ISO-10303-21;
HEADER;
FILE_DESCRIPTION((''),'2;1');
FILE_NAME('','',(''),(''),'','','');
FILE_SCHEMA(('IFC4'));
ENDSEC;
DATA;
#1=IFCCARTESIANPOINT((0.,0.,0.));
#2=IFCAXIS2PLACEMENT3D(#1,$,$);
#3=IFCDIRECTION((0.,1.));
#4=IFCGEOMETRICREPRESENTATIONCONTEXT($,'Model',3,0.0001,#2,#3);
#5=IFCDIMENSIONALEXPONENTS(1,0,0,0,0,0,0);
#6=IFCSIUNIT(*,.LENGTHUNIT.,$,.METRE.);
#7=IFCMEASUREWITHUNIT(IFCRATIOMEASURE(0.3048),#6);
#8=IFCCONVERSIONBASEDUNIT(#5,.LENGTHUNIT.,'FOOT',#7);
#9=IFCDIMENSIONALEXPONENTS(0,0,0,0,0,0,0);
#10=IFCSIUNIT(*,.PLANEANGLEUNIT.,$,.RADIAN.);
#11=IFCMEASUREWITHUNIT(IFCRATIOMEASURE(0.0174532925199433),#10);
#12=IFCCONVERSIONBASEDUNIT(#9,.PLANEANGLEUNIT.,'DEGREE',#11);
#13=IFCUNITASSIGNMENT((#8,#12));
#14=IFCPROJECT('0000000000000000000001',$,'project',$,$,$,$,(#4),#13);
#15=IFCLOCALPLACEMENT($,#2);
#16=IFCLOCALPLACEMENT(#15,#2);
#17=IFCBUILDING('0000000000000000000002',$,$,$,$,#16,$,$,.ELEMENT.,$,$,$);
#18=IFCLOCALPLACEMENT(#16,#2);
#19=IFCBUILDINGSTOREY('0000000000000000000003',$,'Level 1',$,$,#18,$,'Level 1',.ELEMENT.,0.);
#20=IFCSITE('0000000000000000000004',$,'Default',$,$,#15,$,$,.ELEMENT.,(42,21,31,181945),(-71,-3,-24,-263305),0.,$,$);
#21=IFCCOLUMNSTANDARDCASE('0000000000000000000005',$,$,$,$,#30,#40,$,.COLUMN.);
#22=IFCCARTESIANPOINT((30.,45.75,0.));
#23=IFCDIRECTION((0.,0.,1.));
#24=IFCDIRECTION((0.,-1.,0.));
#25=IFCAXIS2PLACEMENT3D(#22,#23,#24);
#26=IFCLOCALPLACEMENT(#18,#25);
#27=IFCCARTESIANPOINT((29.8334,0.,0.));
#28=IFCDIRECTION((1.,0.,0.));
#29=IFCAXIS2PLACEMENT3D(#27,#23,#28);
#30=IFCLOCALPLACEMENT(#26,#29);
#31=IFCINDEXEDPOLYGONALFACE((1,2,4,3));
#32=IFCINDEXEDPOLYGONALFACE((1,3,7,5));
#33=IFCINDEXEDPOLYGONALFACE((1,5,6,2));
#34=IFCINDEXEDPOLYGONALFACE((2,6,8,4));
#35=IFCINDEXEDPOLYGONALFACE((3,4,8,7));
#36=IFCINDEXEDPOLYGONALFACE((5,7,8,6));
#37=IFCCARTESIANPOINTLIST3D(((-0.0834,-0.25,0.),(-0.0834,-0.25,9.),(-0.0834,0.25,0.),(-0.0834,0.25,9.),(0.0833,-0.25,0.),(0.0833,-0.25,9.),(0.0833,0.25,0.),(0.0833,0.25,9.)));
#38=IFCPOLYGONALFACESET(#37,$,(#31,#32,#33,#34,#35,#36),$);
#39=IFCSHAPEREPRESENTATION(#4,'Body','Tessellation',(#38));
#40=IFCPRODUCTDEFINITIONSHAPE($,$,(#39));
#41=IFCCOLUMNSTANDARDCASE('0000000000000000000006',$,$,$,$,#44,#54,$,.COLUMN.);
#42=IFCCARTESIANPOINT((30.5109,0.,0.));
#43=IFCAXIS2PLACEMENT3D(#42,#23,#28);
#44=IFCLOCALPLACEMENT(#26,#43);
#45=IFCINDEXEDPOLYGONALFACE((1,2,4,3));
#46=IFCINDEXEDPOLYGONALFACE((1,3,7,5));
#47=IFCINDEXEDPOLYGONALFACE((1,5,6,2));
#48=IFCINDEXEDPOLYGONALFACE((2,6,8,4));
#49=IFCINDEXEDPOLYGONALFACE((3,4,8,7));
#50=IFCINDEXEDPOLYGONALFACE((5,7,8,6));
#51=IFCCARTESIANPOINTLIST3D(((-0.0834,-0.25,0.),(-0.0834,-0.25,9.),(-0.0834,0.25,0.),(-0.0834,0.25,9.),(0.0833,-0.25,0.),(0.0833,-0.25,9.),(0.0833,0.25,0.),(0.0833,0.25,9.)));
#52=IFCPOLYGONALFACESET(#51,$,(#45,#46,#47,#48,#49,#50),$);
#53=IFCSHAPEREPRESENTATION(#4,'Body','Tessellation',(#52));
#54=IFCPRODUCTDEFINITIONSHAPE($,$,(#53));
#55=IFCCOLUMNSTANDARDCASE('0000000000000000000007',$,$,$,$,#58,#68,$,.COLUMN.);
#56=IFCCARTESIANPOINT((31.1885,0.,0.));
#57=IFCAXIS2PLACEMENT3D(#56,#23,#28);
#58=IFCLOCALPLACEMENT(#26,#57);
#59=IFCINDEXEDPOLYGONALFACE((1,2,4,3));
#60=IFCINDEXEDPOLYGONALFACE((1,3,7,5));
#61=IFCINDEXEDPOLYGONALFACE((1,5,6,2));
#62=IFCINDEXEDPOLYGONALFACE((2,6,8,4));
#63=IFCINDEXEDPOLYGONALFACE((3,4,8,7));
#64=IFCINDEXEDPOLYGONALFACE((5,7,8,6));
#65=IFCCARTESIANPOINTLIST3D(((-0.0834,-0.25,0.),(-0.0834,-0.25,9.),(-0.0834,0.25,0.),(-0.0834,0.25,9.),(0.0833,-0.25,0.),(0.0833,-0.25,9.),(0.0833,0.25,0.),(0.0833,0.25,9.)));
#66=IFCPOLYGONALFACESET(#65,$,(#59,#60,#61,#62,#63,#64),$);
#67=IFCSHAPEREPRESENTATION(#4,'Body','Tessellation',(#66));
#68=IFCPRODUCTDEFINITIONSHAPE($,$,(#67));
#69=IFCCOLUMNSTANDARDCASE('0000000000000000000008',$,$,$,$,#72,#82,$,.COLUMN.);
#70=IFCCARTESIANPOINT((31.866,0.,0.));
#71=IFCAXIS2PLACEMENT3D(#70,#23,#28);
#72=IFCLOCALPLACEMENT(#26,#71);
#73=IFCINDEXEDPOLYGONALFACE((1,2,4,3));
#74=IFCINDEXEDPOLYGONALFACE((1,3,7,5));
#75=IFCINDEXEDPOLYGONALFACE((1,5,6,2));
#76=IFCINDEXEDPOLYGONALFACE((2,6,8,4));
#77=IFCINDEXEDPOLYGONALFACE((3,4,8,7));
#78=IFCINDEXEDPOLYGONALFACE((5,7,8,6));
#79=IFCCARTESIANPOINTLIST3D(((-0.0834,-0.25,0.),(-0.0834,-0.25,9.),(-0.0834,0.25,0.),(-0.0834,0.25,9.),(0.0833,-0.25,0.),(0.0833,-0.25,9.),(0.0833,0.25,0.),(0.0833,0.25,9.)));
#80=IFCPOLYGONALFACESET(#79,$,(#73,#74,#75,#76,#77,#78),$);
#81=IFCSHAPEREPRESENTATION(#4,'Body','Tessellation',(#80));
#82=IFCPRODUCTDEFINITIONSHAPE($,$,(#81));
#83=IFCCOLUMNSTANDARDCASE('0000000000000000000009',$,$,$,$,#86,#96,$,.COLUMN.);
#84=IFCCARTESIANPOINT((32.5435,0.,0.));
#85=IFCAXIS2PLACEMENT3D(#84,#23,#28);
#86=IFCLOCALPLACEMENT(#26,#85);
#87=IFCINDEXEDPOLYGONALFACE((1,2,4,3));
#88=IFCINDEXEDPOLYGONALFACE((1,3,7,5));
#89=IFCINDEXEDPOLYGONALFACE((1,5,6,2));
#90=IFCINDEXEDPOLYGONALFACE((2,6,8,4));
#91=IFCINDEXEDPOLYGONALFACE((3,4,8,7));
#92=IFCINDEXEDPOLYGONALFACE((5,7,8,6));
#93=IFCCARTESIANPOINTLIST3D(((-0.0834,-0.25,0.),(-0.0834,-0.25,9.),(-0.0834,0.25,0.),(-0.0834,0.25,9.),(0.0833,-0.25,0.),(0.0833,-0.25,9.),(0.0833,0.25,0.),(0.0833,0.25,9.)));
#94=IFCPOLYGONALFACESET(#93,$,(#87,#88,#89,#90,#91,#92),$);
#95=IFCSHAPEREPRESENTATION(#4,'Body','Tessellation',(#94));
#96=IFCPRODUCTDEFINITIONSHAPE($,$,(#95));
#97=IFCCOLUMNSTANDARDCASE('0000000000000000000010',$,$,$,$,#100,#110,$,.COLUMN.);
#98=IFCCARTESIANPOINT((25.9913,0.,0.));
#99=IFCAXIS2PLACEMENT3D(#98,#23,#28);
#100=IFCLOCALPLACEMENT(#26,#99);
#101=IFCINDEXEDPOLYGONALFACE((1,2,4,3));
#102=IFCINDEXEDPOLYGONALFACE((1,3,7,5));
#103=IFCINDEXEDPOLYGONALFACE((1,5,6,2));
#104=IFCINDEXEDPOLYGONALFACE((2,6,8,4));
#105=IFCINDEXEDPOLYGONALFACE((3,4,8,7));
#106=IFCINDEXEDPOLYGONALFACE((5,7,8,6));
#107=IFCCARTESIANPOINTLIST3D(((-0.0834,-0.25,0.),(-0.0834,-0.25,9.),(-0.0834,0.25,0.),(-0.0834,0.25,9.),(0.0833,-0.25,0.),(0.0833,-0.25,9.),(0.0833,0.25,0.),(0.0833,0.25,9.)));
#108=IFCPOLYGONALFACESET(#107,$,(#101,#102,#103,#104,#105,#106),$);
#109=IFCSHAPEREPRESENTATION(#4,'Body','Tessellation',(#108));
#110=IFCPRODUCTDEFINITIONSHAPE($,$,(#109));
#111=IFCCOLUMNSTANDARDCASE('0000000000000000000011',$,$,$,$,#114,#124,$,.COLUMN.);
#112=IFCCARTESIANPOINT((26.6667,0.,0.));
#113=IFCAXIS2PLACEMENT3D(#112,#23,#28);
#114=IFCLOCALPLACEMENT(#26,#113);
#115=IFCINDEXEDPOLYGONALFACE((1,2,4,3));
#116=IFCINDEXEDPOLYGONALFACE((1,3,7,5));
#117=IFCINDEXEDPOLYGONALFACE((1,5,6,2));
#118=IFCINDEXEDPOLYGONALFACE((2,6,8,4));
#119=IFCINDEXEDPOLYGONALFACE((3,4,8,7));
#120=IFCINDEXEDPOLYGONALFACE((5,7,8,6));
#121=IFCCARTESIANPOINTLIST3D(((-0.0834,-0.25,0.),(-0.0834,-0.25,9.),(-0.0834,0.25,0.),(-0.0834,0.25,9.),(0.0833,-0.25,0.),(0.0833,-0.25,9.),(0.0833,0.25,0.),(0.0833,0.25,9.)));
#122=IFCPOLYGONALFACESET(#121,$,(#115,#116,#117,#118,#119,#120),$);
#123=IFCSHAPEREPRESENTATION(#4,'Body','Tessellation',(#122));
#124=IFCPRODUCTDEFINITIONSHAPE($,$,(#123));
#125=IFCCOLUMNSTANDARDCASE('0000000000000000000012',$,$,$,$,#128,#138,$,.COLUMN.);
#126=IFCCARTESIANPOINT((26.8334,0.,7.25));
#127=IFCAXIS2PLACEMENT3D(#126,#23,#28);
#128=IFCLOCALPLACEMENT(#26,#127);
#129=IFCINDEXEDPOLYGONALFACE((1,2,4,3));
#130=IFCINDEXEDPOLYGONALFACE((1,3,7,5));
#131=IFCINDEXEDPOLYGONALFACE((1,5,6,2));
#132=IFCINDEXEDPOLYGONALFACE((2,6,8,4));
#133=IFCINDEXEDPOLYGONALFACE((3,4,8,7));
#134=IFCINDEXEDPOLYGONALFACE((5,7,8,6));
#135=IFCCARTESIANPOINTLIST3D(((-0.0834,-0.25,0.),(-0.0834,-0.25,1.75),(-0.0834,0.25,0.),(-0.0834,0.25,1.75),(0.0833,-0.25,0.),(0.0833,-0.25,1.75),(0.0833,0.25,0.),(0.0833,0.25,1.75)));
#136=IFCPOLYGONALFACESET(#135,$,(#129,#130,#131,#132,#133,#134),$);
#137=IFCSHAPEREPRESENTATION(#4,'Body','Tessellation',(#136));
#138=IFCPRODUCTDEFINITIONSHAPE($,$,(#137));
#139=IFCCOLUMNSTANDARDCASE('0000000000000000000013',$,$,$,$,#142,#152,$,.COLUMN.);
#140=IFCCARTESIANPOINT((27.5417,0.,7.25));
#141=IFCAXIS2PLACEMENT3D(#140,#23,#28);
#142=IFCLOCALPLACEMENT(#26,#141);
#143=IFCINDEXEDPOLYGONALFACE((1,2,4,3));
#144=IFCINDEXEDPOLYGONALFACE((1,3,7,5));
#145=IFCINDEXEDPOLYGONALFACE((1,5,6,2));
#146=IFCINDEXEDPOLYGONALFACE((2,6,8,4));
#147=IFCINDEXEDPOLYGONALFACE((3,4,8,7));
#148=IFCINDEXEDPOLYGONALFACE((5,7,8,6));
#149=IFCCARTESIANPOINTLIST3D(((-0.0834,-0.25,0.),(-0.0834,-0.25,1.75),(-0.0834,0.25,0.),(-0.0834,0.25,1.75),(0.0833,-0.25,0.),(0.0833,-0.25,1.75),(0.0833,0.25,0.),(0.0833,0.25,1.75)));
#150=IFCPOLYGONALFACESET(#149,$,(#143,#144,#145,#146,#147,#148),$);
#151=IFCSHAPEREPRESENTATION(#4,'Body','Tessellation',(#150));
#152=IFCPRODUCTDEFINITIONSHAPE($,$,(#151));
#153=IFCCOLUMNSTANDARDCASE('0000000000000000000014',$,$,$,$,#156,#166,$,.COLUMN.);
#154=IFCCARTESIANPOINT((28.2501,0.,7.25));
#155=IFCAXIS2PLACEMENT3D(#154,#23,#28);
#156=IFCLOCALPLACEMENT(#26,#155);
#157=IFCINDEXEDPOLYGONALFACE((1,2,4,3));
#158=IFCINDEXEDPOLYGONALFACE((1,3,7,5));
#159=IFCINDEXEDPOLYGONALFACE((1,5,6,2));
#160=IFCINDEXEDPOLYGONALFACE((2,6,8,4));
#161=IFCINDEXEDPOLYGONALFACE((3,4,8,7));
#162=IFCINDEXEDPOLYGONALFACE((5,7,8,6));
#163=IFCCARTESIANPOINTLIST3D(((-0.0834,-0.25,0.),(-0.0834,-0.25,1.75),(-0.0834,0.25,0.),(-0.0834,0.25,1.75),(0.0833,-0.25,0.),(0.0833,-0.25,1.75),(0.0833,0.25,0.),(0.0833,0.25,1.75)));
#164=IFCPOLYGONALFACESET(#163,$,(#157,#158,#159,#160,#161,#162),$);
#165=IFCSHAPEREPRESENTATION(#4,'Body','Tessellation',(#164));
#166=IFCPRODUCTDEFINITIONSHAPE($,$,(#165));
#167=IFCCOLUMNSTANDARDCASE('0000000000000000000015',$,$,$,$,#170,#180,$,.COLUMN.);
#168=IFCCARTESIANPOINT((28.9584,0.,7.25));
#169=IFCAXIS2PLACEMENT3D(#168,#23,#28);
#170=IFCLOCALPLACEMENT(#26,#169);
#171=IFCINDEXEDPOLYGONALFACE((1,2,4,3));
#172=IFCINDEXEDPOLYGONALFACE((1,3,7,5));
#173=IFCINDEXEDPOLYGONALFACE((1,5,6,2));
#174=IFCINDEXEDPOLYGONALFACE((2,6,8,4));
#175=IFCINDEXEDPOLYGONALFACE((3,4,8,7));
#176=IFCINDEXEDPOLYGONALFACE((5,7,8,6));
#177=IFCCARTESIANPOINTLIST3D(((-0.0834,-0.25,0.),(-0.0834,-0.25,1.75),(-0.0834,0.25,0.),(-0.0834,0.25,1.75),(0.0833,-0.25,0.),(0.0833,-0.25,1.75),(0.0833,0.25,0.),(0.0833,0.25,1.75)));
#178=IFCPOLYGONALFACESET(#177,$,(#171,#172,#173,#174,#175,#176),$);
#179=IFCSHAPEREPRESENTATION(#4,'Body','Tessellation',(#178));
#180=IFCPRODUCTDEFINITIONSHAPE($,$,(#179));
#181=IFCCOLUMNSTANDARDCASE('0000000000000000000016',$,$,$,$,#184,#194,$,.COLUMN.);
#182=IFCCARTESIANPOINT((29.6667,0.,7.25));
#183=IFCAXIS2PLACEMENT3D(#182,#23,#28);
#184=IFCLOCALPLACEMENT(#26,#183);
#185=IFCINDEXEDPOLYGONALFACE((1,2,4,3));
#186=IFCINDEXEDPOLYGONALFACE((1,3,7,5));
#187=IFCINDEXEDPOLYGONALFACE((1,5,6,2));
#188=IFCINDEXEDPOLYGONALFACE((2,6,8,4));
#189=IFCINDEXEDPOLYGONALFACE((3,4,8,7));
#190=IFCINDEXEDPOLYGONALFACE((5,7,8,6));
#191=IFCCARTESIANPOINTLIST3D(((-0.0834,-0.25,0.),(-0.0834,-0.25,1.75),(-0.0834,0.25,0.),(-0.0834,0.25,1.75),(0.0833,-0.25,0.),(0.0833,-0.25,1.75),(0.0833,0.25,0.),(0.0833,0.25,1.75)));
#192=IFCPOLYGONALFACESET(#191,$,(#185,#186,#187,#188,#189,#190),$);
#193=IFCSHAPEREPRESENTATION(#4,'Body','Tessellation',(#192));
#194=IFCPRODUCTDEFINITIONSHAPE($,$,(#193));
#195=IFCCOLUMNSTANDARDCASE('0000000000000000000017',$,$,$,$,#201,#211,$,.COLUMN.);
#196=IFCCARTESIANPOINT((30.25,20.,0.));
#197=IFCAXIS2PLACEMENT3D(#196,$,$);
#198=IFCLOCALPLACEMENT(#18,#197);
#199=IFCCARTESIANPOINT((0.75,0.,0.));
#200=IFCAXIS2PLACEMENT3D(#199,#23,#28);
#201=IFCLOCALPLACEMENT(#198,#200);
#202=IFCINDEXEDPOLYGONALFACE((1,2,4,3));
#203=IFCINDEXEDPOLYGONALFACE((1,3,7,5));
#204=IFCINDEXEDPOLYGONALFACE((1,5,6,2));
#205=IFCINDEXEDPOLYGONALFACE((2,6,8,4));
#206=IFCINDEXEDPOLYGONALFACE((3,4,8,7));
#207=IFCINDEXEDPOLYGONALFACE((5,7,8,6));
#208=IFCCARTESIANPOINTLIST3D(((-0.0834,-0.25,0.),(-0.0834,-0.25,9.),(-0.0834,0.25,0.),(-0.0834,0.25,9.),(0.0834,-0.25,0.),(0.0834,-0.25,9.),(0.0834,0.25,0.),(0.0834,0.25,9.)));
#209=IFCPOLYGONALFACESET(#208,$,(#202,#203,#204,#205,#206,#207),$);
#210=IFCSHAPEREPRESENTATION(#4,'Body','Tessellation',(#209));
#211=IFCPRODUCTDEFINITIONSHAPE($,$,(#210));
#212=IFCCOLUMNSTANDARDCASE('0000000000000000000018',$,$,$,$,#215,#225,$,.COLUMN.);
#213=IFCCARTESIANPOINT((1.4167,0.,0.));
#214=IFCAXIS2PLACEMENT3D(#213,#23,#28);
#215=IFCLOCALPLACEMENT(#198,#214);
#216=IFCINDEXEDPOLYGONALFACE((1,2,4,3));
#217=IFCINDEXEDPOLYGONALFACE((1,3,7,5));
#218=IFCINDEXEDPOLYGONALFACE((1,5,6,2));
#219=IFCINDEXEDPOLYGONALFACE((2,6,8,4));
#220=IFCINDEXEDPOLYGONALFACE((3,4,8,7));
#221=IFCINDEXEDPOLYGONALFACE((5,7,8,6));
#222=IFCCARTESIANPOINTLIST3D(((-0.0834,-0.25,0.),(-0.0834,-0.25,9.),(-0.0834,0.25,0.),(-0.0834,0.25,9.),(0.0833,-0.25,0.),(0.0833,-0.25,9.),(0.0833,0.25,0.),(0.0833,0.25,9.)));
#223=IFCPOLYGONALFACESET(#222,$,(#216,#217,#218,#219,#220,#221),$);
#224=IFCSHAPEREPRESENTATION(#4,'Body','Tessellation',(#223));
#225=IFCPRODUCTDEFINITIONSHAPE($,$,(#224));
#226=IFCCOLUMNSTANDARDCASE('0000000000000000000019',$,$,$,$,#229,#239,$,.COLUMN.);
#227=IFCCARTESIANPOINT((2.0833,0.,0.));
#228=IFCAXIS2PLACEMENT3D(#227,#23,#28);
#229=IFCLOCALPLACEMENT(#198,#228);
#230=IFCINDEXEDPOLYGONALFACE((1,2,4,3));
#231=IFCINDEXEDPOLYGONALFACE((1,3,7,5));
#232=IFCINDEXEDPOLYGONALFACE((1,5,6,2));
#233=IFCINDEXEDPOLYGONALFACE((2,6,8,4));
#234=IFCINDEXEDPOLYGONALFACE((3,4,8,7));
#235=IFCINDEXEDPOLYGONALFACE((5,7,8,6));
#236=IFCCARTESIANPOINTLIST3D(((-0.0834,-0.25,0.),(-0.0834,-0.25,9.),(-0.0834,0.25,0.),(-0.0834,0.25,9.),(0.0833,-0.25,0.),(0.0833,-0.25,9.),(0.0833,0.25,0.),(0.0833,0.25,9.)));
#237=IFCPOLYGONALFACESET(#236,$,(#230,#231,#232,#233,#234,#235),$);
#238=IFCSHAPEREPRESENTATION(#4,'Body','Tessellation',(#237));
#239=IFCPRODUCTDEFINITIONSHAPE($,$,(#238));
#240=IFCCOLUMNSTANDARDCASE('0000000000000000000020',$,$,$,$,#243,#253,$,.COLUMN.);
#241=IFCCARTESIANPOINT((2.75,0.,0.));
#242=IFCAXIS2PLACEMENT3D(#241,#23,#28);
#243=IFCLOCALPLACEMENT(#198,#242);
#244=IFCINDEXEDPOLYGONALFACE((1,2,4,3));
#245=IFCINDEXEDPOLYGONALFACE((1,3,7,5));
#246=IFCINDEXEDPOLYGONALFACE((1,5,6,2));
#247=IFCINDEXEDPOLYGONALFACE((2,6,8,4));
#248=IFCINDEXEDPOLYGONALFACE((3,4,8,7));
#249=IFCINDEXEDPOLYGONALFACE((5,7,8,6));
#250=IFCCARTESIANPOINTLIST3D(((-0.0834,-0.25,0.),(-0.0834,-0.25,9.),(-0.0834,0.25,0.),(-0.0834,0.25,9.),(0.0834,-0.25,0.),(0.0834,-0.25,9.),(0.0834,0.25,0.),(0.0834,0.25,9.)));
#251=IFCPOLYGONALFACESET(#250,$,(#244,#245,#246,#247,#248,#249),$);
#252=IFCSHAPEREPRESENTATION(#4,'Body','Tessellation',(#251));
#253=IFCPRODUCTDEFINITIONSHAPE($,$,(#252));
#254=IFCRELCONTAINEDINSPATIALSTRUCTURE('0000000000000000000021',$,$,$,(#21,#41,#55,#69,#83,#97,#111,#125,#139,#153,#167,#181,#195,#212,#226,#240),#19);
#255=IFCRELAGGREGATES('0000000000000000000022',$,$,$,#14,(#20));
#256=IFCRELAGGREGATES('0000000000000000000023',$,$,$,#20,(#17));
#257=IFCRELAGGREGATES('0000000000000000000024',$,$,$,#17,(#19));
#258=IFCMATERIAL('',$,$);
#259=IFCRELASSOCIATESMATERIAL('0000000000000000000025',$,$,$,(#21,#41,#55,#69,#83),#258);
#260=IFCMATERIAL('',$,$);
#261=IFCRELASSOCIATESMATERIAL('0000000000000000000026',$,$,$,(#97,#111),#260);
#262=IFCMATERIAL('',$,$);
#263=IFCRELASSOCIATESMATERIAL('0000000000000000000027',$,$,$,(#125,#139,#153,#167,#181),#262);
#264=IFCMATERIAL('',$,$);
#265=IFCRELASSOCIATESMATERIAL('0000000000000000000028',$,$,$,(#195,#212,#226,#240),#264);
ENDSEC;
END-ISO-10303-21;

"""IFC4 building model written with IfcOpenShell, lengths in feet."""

from ifc_helpers import new_model, entity, si_unit, converted_unit, direction, frame, origin, place, context, project, spatial, rectangle, extrude, material, element, save


model = new_model("IFC4")

# Units and contexts
model_context = context("Model", 3, precision=0.0001, world=origin(), true_north=direction((0.0, 1.0)))
ifc_project = project(units=[converted_unit("LENGTHUNIT", "FOOT", entity("IfcRatioMeasure", 0.3048), si_unit("LENGTHUNIT", "METRE"), dimensions=[1, 0, 0, 0, 0, 0, 0]), converted_unit("PLANEANGLEUNIT", "DEGREE", entity("IfcRatioMeasure", 0.0174532925199433), si_unit("PLANEANGLEUNIT", "RADIAN"), dimensions=[0, 0, 0, 0, 0, 0, 0])], contexts=[model_context])

# Site, building, storey
site_placement = place(None, origin())
site = spatial("IfcSite", under=ifc_project, at=site_placement, Name="Default", CompositionType="ELEMENT", RefLatitude=(42, 21, 31, 181945), RefLongitude=(-71, -3, -24, -263305), RefElevation=0.0)
building_placement = place(site_placement, origin())
building = spatial("IfcBuilding", under=site, at=building_placement, CompositionType="ELEMENT")
storey_placement = place(building_placement, origin())
storey = spatial("IfcBuildingStorey", under=building, at=storey_placement, Name="Level 1", LongName="Level 1", CompositionType="ELEMENT", Elevation=0.0)

# Columns
ifc_material_1 = material(Name="")
ifc_material_2 = material(Name="")
placement_1 = place(storey_placement, frame((30.0, 45.75, 0.0), z_axis=(0.0, 0.0, 1.0), x_axis=(0.0, -1.0, 0.0)))
for number, where, z_axis, x_axis in (
    (1, (29.8334, 0.0, 0.0), (0.0, 0.0, 1.0), (1.0, 0.0, 0.0)),
    (2, (30.5109, 0.0, 0.0), (0.0, 0.0, 1.0), (1.0, 0.0, 0.0)),
    (3, (31.1885, 0.0, 0.0), (0.0, 0.0, 1.0), (1.0, 0.0, 0.0)),
    (4, (31.866, 0.0, 0.0), (0.0, 0.0, 1.0), (1.0, 0.0, 0.0)),
    (5, (32.5435, 0.0, 0.0), (0.0, 0.0, 1.0), (1.0, 0.0, 0.0)),
):
    element("IfcColumnStandardCase", number, at=place(placement_1, frame(where, z_axis=z_axis, x_axis=x_axis)), inside=storey, material=ifc_material_2, PredefinedType="COLUMN", context=model_context, shape_type="SweptSolid", body=[
        extrude(rectangle(XDim=0.1667, YDim=0.5), origin(), (0.0, 0.0, 1.0), 9.0),
    ])
ifc_material_3 = material(Name="")
for number, where, z_axis, x_axis in (
    (6, (25.9913, 0.0, 0.0), (0.0, 0.0, 1.0), (1.0, 0.0, 0.0)),
    (7, (26.6667, 0.0, 0.0), (0.0, 0.0, 1.0), (1.0, 0.0, 0.0)),
):
    element("IfcColumnStandardCase", number, at=place(placement_1, frame(where, z_axis=z_axis, x_axis=x_axis)), inside=storey, material=ifc_material_3, PredefinedType="COLUMN", context=model_context, shape_type="SweptSolid", body=[
        extrude(rectangle(XDim=0.1667, YDim=0.5), origin(), (0.0, 0.0, 1.0), 9.0),
    ])
ifc_material_4 = material(Name="")
for number, where, z_axis, x_axis in (
    (8, (26.8334, 0.0, 7.25), (0.0, 0.0, 1.0), (1.0, 0.0, 0.0)),
    (9, (27.5417, 0.0, 7.25), (0.0, 0.0, 1.0), (1.0, 0.0, 0.0)),
    (10, (28.2501, 0.0, 7.25), (0.0, 0.0, 1.0), (1.0, 0.0, 0.0)),
    (11, (28.9584, 0.0, 7.25), (0.0, 0.0, 1.0), (1.0, 0.0, 0.0)),
    (12, (29.6667, 0.0, 7.25), (0.0, 0.0, 1.0), (1.0, 0.0, 0.0)),
):
    element("IfcColumnStandardCase", number, at=place(placement_1, frame(where, z_axis=z_axis, x_axis=x_axis)), inside=storey, material=ifc_material_4, PredefinedType="COLUMN", context=model_context, shape_type="SweptSolid", body=[
        extrude(rectangle(XDim=0.1667, YDim=0.5), origin(), (0.0, 0.0, 1.0), 1.75),
    ])
placement_2 = place(storey_placement, frame((30.25, 20.0, 0.0)))
for number, where, z_axis, x_axis in (
    (13, (0.75, 0.0, 0.0), (0.0, 0.0, 1.0), (1.0, 0.0, 0.0)),
    (14, (1.4167, 0.0, 0.0), (0.0, 0.0, 1.0), (1.0, 0.0, 0.0)),
    (15, (2.0833, 0.0, 0.0), (0.0, 0.0, 1.0), (1.0, 0.0, 0.0)),
    (16, (2.75, 0.0, 0.0), (0.0, 0.0, 1.0), (1.0, 0.0, 0.0)),
):
    element("IfcColumnStandardCase", number, at=place(placement_2, frame(where, z_axis=z_axis, x_axis=x_axis)), inside=storey, material=ifc_material_1, PredefinedType="COLUMN", context=model_context, shape_type="SweptSolid", body=[
        extrude(rectangle(XDim=0.1667, YDim=0.5), origin(), (0.0, 0.0, 1.0), 9.0),
    ])

save(model, "model.ifc")
